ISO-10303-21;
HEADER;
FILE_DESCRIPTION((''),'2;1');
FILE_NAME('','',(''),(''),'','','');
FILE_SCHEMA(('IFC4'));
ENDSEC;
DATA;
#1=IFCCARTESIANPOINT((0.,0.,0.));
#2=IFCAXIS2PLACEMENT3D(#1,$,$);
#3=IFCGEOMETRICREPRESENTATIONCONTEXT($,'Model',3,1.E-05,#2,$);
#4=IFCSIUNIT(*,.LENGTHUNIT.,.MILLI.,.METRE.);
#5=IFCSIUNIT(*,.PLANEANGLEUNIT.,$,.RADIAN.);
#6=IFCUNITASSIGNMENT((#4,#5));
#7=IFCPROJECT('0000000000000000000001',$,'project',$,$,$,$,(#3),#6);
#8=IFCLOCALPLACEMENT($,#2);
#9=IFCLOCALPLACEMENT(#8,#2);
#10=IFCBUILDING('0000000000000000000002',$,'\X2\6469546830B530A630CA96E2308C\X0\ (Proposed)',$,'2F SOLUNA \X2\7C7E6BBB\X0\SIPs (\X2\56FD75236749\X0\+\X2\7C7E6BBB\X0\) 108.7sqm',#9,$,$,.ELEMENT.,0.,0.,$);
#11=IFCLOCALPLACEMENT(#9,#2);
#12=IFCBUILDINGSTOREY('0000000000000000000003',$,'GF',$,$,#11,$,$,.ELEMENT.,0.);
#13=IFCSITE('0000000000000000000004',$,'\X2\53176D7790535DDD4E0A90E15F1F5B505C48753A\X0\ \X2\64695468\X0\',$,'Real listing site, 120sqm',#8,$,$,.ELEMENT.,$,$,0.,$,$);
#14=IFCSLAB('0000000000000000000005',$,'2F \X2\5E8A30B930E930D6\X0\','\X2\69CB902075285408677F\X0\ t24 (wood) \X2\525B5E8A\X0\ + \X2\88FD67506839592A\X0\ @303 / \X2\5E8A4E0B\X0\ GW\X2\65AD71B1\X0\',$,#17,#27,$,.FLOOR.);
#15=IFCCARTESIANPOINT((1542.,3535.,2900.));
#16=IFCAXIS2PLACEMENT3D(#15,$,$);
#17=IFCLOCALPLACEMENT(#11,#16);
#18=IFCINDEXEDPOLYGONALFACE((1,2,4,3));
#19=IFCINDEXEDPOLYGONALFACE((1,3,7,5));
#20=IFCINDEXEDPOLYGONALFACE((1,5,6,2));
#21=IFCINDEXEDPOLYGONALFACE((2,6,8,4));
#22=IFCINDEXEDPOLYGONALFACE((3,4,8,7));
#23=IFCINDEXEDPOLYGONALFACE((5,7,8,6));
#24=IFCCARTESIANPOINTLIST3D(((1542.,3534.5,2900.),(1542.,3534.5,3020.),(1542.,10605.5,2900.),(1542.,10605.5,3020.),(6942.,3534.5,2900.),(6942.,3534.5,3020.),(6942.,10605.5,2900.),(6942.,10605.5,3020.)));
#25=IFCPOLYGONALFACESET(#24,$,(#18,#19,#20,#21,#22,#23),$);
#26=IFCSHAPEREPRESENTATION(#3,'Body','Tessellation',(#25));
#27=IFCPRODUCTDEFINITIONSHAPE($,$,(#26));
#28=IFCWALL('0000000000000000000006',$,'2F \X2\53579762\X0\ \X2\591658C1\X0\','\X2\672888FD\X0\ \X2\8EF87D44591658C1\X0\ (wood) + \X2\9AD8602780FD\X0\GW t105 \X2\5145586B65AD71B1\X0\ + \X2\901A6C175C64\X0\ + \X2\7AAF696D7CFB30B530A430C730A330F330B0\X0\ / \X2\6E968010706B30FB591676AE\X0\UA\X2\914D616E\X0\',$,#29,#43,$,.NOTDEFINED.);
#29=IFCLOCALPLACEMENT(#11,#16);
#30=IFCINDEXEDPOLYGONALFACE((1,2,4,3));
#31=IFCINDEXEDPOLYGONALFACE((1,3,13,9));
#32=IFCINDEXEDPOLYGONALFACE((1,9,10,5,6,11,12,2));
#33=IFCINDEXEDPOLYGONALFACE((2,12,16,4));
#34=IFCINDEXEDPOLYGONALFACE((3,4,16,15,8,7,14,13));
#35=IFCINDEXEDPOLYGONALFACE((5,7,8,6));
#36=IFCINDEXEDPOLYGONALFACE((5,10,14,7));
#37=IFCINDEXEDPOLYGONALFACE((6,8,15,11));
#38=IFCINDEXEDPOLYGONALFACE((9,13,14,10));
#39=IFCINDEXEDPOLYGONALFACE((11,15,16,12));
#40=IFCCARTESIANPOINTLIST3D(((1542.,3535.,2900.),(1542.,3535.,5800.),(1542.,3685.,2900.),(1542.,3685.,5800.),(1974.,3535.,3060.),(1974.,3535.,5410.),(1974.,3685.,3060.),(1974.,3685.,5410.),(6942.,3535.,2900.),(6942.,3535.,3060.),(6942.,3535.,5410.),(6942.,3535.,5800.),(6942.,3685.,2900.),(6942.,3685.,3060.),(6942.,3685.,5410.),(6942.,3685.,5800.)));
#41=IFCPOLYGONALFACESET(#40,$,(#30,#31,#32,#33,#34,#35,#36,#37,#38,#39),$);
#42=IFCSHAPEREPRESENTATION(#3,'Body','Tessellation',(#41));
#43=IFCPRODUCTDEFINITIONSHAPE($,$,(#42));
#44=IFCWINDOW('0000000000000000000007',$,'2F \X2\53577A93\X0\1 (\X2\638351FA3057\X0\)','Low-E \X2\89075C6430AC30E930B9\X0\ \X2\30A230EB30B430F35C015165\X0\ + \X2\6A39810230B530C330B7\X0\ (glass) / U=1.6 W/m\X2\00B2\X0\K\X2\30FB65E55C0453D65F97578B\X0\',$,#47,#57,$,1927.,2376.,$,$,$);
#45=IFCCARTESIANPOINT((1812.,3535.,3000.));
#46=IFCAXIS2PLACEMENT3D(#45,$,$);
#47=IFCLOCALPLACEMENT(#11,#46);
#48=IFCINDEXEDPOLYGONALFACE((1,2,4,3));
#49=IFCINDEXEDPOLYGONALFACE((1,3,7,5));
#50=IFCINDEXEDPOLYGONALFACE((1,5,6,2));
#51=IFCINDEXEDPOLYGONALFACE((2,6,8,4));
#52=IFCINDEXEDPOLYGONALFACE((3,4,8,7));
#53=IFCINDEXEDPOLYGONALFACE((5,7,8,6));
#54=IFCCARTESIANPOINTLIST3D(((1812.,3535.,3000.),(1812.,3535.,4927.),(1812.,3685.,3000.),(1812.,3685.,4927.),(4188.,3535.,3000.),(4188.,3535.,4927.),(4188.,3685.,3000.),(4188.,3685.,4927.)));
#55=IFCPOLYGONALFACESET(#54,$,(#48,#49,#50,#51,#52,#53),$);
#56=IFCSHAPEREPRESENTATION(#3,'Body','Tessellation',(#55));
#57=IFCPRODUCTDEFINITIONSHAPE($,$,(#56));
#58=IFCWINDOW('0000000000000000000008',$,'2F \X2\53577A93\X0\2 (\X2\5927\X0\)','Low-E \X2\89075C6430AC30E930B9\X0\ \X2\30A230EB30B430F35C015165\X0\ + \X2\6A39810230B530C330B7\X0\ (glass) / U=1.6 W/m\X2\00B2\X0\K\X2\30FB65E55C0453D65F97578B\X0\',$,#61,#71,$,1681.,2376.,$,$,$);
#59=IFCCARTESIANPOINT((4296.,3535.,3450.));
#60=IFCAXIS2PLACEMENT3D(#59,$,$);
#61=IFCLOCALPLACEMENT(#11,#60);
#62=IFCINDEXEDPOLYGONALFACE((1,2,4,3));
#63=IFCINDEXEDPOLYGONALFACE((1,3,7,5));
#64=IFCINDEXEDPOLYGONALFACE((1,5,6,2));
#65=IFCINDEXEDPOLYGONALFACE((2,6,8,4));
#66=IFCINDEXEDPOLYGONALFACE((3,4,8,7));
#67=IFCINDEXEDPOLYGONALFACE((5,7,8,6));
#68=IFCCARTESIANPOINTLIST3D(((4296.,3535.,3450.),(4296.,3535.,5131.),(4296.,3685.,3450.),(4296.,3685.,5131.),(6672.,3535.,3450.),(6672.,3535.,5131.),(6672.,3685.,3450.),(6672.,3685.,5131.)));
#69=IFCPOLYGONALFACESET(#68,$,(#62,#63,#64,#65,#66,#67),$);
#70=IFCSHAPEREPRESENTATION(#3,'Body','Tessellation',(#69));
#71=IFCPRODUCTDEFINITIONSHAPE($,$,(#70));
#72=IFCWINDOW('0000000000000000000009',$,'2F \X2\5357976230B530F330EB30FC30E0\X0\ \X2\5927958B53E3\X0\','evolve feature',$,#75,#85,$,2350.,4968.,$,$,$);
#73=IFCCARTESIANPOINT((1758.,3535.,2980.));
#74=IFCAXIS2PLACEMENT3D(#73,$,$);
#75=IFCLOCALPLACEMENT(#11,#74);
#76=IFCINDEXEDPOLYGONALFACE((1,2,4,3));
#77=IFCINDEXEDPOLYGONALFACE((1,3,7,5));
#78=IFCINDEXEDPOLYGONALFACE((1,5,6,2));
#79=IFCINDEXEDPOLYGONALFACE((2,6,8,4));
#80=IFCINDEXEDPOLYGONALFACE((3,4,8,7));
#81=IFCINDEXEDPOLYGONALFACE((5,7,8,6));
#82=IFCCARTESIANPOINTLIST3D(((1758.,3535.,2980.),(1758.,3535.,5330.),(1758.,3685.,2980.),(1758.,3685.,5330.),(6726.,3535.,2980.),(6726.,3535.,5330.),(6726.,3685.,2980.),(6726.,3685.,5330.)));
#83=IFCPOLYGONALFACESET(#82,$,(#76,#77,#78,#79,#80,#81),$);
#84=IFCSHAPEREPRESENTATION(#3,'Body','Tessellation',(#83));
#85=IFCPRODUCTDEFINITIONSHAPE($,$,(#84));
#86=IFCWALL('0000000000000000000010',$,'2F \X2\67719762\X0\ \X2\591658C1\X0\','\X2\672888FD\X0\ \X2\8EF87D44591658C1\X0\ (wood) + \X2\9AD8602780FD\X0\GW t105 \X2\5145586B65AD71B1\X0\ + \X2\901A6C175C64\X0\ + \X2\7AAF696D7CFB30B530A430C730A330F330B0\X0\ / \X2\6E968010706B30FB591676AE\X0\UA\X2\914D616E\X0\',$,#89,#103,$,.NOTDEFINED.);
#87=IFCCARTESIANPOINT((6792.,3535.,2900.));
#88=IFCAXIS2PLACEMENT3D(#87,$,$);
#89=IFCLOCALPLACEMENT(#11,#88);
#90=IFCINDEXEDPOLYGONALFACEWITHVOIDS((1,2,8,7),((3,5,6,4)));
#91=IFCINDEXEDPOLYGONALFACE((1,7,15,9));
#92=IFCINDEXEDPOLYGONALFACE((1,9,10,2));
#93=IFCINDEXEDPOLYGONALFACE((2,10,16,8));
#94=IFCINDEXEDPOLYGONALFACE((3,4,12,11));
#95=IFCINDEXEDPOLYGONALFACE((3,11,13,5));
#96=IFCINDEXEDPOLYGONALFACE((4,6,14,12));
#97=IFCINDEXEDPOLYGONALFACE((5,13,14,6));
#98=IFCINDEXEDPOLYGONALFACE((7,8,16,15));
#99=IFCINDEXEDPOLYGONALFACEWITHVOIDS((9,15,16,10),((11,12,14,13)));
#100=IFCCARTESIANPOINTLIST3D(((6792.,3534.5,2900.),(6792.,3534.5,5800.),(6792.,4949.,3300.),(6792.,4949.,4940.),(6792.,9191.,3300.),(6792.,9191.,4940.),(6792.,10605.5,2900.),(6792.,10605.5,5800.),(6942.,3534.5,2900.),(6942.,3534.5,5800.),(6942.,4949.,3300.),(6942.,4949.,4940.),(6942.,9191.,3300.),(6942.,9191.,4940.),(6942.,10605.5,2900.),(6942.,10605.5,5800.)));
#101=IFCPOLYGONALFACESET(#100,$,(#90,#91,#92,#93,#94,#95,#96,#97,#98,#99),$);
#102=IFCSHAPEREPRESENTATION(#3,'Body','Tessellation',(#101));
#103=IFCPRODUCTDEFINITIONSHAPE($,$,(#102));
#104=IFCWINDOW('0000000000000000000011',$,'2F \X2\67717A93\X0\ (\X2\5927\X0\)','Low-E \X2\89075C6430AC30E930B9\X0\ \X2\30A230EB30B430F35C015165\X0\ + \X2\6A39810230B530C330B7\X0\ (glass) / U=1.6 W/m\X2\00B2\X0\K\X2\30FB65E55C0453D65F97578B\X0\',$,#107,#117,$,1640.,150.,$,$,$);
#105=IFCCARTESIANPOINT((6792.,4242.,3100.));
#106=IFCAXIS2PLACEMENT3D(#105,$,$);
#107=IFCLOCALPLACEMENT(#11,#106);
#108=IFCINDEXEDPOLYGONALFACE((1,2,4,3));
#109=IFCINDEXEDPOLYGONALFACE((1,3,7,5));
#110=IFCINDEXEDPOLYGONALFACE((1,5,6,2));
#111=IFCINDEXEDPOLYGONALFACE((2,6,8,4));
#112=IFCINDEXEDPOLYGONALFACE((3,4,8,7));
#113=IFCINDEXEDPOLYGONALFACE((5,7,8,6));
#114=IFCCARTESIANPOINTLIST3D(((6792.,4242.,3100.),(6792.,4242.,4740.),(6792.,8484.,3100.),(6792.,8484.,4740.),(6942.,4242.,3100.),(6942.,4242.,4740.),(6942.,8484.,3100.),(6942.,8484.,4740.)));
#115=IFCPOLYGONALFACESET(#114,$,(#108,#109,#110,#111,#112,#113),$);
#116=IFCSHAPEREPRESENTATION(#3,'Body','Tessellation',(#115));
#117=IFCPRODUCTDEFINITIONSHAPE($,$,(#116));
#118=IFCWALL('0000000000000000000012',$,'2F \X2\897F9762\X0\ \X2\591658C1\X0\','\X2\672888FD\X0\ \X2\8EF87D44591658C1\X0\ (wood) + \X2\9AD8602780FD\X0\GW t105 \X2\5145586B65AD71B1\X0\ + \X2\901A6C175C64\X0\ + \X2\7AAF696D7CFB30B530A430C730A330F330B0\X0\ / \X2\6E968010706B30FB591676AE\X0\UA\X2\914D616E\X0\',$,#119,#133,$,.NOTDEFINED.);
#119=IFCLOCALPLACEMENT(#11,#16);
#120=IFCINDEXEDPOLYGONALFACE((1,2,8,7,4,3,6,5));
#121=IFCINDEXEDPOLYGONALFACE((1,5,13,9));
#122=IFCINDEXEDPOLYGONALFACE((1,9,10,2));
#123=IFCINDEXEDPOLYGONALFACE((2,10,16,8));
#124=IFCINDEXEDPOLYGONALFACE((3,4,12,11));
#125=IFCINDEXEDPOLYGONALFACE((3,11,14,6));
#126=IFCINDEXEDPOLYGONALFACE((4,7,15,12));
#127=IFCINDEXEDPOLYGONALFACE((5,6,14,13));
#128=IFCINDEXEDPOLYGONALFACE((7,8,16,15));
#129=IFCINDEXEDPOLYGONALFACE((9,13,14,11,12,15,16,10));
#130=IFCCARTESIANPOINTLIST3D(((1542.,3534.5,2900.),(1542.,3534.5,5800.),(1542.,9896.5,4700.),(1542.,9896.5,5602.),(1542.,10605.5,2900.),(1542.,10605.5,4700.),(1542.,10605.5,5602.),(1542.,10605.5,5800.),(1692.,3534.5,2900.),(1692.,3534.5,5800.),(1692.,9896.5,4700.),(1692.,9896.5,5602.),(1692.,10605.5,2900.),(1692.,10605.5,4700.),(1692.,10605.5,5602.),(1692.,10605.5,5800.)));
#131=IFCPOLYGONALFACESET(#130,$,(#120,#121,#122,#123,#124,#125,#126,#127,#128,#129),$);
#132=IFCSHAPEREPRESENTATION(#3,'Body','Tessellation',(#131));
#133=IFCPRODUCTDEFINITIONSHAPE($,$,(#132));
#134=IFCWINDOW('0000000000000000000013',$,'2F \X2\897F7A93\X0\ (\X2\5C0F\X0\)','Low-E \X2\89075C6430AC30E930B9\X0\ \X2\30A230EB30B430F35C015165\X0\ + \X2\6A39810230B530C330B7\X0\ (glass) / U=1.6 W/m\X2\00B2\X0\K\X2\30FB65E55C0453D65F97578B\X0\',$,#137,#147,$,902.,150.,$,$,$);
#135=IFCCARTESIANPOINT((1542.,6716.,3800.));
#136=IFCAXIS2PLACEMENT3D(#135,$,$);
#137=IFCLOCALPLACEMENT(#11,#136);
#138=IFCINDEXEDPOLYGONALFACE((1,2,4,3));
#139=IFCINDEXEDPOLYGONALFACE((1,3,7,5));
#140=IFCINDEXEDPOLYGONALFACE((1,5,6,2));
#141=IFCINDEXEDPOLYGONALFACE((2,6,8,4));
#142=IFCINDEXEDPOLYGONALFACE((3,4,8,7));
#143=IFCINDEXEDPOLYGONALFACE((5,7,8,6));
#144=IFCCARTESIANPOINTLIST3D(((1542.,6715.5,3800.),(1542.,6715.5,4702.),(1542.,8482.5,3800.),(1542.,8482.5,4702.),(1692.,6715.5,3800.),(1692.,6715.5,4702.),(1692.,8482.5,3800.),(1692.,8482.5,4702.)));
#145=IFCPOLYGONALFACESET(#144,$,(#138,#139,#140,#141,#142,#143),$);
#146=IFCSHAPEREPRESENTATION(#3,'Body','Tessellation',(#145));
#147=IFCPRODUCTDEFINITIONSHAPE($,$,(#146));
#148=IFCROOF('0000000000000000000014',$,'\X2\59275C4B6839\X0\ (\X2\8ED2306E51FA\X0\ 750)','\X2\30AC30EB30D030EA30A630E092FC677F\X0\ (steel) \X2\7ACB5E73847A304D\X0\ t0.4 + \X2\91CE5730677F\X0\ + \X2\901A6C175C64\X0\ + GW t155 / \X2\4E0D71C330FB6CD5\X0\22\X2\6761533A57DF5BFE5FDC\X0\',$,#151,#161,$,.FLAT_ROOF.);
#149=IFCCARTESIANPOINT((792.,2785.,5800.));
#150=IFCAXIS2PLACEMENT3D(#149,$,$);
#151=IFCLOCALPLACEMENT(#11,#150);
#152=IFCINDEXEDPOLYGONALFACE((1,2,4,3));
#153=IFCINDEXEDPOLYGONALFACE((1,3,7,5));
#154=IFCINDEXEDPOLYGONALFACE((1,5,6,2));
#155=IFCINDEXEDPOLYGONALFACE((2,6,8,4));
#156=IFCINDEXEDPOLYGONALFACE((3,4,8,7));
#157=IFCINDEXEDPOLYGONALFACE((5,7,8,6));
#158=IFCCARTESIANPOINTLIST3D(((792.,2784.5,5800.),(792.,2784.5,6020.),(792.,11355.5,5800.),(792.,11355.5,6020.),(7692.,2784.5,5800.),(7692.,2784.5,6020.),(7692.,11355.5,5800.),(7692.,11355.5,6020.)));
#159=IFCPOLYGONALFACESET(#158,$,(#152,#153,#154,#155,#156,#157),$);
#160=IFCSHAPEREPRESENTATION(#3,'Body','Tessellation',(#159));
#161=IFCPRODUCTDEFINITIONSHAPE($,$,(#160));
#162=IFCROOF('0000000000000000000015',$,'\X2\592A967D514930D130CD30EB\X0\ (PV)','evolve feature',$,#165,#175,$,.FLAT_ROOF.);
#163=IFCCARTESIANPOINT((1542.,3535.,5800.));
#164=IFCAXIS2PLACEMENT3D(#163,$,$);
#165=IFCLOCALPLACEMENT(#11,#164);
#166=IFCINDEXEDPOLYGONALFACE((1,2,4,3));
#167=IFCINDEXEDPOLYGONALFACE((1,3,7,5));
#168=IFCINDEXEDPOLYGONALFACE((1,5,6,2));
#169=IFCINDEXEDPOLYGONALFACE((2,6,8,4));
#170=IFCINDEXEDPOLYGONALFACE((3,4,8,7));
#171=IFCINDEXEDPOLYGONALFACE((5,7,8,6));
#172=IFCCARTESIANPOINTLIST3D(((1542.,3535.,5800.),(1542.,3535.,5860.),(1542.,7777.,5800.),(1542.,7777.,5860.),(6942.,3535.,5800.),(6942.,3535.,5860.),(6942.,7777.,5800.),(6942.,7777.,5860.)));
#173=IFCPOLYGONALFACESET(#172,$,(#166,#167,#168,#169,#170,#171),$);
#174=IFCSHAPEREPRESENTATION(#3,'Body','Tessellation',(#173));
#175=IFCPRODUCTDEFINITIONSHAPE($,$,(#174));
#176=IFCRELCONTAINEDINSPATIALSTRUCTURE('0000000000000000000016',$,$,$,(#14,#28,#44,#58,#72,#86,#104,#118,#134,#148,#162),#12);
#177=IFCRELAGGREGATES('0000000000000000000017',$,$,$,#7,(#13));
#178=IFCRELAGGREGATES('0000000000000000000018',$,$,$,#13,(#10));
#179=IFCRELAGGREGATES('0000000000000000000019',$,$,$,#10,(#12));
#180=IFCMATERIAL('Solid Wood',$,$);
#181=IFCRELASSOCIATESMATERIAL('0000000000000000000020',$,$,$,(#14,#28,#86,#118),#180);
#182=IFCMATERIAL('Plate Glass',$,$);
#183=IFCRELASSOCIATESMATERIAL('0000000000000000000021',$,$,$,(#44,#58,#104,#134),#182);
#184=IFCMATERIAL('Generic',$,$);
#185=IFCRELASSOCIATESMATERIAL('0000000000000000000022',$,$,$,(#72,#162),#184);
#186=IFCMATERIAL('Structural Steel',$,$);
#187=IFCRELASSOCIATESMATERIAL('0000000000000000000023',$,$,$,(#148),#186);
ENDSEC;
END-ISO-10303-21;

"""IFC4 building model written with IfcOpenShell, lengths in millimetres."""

from ifc_helpers import new_model, si_unit, frame, frame_2d, origin, place, context, project, spatial, rectangle, extrude, material, element, fill, save


model = new_model("IFC4")

# Units and contexts
model_context = context("Model", 3, precision=1e-05, world=origin())
ifc_project = project(units=[si_unit("LENGTHUNIT", "METRE", prefix="MILLI"), si_unit("PLANEANGLEUNIT", "RADIAN")], contexts=[model_context])

# Site, building, storey
site_placement = place(None, origin())
site = spatial("IfcSite", under=ifc_project, at=site_placement, Name="北海道川上郡弟子屈町 摩周", ObjectType="Real listing site, 120sqm", CompositionType="ELEMENT", RefElevation=0.0)
building_placement = place(site_placement, origin())
building = spatial("IfcBuilding", under=site, at=building_placement, Name="摩周サウナ離れ (Proposed)", ObjectType="2F SOLUNA 籾殻SIPs (国産杉+籾殻) 108.7sqm", CompositionType="ELEMENT", ElevationOfRefHeight=0.0, ElevationOfTerrain=0.0)
storey_placement = place(building_placement, origin())
storey = spatial("IfcBuildingStorey", under=building, at=storey_placement, Name="GF", CompositionType="ELEMENT", Elevation=0.0)

# Slab
ifc_material_1 = material(Name="Solid Wood")
slab_placement = place(storey_placement, frame((1542.0, 3535.0, 2900.0)))
element("IfcSlab", 1, at=slab_placement, inside=storey, material=ifc_material_1, Name="2F 床スラブ", Description="構造用合板 t24 (wood) 剛床 + 製材根太 @303 / 床下 GW断熱", PredefinedType="FLOOR", context=model_context, shape_type="SweptSolid", body=[
    extrude(rectangle(XDim=5400.0, YDim=7071.0, at=frame_2d((2700.0, 3535.0))), frame((1542.0, 3535.0, 2900.0)), (0.0, 0.0, 1.0), 120.0),
])

# Wall, openings, windows
wall_1_placement = place(storey_placement, frame((1542.0, 3535.0, 2900.0)))
wall_1 = element("IfcWall", 2, at=wall_1_placement, inside=storey, material=ifc_material_1, Name="2F 南面 外壁", Description="木製 軸組外壁 (wood) + 高性能GW t105 充填断熱 + 通気層 + 窯業系サイディング / 準耐火・外皮UA配慮", PredefinedType="NOTDEFINED", context=model_context, shape_type="SweptSolid", body=[
    extrude(rectangle(XDim=5400.0, YDim=150.0, at=frame_2d((2700.0, 75.0))), frame((1542.0, 3535.0, 2900.0)), (0.0, 0.0, 1.0), 2900.0),
])
opening_1_placement = place(storey_placement, frame((1812.0, 3535.0, 3000.0)))
opening_1 = element("IfcOpeningElement", 3, at=opening_1_placement, cuts=wall_1, PredefinedType="NOTDEFINED", context=model_context, shape_type="SweptSolid", body=[
    extrude(rectangle(XDim=2376.0, YDim=150.0, at=frame_2d((1188.0, 75.0))), frame((1812.0, 3535.0, 3000.0)), (0.0, 0.0, 1.0), 1927.0),
])
opening_2_placement = place(storey_placement, frame((4296.0, 3535.0, 3450.0)))
opening_2 = element("IfcOpeningElement", 4, at=opening_2_placement, cuts=wall_1, PredefinedType="NOTDEFINED", context=model_context, shape_type="SweptSolid", body=[
    extrude(rectangle(XDim=2376.0, YDim=150.0, at=frame_2d((1188.0, 75.0))), frame((4296.0, 3535.0, 3450.0)), (0.0, 0.0, 1.0), 1681.0),
])
opening_3_placement = place(storey_placement, frame((1758.0, 3535.0, 2980.0)))
opening_3 = element("IfcOpeningElement", 5, at=opening_3_placement, cuts=wall_1, PredefinedType="NOTDEFINED", context=model_context, shape_type="SweptSolid", body=[
    extrude(rectangle(XDim=4968.0, YDim=150.0, at=frame_2d((2484.0, 75.0))), frame((1758.0, 3535.0, 2980.0)), (0.0, 0.0, 1.0), 2350.0),
])
ifc_material_2 = material(Name="Plate Glass")
window_1_placement = place(storey_placement, frame((1812.0, 3535.0, 3000.0)))
window_1 = element("IfcWindow", 6, at=window_1_placement, inside=storey, material=ifc_material_2, Name="2F 南窓1 (掃出し)", Description="Low-E 複層ガラス アルゴン封入 + 樹脂サッシ (glass) / U=1.6 W/m²K・日射取得型", OverallHeight=1927.0, OverallWidth=2376.0, context=model_context, shape_type="SweptSolid", body=[
    extrude(rectangle(XDim=2376.0, YDim=150.0, at=frame_2d((1188.0, 75.0))), frame((1812.0, 3535.0, 3000.0)), (0.0, 0.0, 1.0), 1927.0),
])
fill(opening_1, window_1)
window_2_placement = place(storey_placement, frame((4296.0, 3535.0, 3450.0)))
window_2 = element("IfcWindow", 7, at=window_2_placement, inside=storey, material=ifc_material_2, Name="2F 南窓2 (大)", Description="Low-E 複層ガラス アルゴン封入 + 樹脂サッシ (glass) / U=1.6 W/m²K・日射取得型", OverallHeight=1681.0, OverallWidth=2376.0, context=model_context, shape_type="SweptSolid", body=[
    extrude(rectangle(XDim=2376.0, YDim=150.0, at=frame_2d((1188.0, 75.0))), frame((4296.0, 3535.0, 3450.0)), (0.0, 0.0, 1.0), 1681.0),
])
fill(opening_2, window_2)
ifc_material_3 = material(Name="Generic")
window_3_placement = place(storey_placement, frame((1758.0, 3535.0, 2980.0)))
window_3 = element("IfcWindow", 8, at=window_3_placement, inside=storey, material=ifc_material_3, Name="2F 南面サンルーム 大開口", Description="evolve feature", OverallHeight=2350.0, OverallWidth=4968.0, context=model_context, shape_type="SweptSolid", body=[
    extrude(rectangle(XDim=4968.0, YDim=150.0, at=frame_2d((2484.0, 75.0))), frame((1758.0, 3535.0, 2980.0)), (0.0, 0.0, 1.0), 2350.0),
])
fill(opening_3, window_3)

# Walls, openings, windows
wall_2_placement = place(storey_placement, frame((6792.0, 3535.0, 2900.0)))
wall_2 = element("IfcWall", 9, at=wall_2_placement, inside=storey, material=ifc_material_1, Name="2F 東面 外壁", Description="木製 軸組外壁 (wood) + 高性能GW t105 充填断熱 + 通気層 + 窯業系サイディング / 準耐火・外皮UA配慮", PredefinedType="NOTDEFINED", context=model_context, shape_type="SweptSolid", body=[
    extrude(rectangle(XDim=150.0, YDim=7071.0, at=frame_2d((75.0, 3535.0))), frame((6792.0, 3535.0, 2900.0)), (0.0, 0.0, 1.0), 2900.0),
])
opening_4_placement = place(storey_placement, frame((6792.0, 4242.0, 3100.0)))
opening_4 = element("IfcOpeningElement", 10, at=opening_4_placement, cuts=wall_2, PredefinedType="NOTDEFINED", context=model_context, shape_type="SweptSolid", body=[
    extrude(rectangle(XDim=150.0, YDim=4242.0, at=frame_2d((75.0, 2121.0))), frame((6792.0, 4242.0, 3100.0)), (0.0, 0.0, 1.0), 1640.0),
])
window_4_placement = place(storey_placement, frame((6792.0, 4242.0, 3100.0)))
window_4 = element("IfcWindow", 11, at=window_4_placement, inside=storey, material=ifc_material_2, Name="2F 東窓 (大)", Description="Low-E 複層ガラス アルゴン封入 + 樹脂サッシ (glass) / U=1.6 W/m²K・日射取得型", OverallHeight=1640.0, OverallWidth=150.0, context=model_context, shape_type="SweptSolid", body=[
    extrude(rectangle(XDim=150.0, YDim=4242.0, at=frame_2d((75.0, 2121.0))), frame((6792.0, 4242.0, 3100.0)), (0.0, 0.0, 1.0), 1640.0),
])
fill(opening_4, window_4)
wall_3_placement = place(storey_placement, frame((1542.0, 3535.0, 2900.0)))
wall_3 = element("IfcWall", 12, at=wall_3_placement, inside=storey, material=ifc_material_1, Name="2F 西面 外壁", Description="木製 軸組外壁 (wood) + 高性能GW t105 充填断熱 + 通気層 + 窯業系サイディング / 準耐火・外皮UA配慮", PredefinedType="NOTDEFINED", context=model_context, shape_type="SweptSolid", body=[
    extrude(rectangle(XDim=150.0, YDim=7071.0, at=frame_2d((75.0, 3535.0))), frame((1542.0, 3535.0, 2900.0)), (0.0, 0.0, 1.0), 2900.0),
])
opening_5_placement = place(storey_placement, frame((1542.0, 6716.0, 3800.0)))
opening_5 = element("IfcOpeningElement", 13, at=opening_5_placement, cuts=wall_3, PredefinedType="NOTDEFINED", context=model_context, shape_type="SweptSolid", body=[
    extrude(rectangle(XDim=150.0, YDim=1767.0, at=frame_2d((75.0, 883.0))), frame((1542.0, 6716.0, 3800.0)), (0.0, 0.0, 1.0), 902.0),
])
window_5_placement = place(storey_placement, frame((1542.0, 6716.0, 3800.0)))
window_5 = element("IfcWindow", 14, at=window_5_placement, inside=storey, material=ifc_material_2, Name="2F 西窓 (小)", Description="Low-E 複層ガラス アルゴン封入 + 樹脂サッシ (glass) / U=1.6 W/m²K・日射取得型", OverallHeight=902.0, OverallWidth=150.0, context=model_context, shape_type="SweptSolid", body=[
    extrude(rectangle(XDim=150.0, YDim=1767.0, at=frame_2d((75.0, 883.0))), frame((1542.0, 6716.0, 3800.0)), (0.0, 0.0, 1.0), 902.0),
])
fill(opening_5, window_5)

# Roofs
ifc_material_4 = material(Name="Structural Steel")
roof_1_placement = place(storey_placement, frame((792.0, 2785.0, 5800.0)))
element("IfcRoof", 15, at=roof_1_placement, inside=storey, material=ifc_material_4, Name="大屋根 (軒の出 750)", Description="ガルバリウム鋼板 (steel) 立平葺き t0.4 + 野地板 + 通気層 + GW t155 / 不燃・法22条区域対応", PredefinedType="FLAT_ROOF", context=model_context, shape_type="SweptSolid", body=[
    extrude(rectangle(XDim=6900.0, YDim=8571.0, at=frame_2d((3450.0, 4285.0))), frame((792.0, 2785.0, 5800.0)), (0.0, 0.0, 1.0), 220.0),
])
roof_2_placement = place(storey_placement, frame((1542.0, 3535.0, 5800.0)))
element("IfcRoof", 16, at=roof_2_placement, inside=storey, material=ifc_material_3, Name="太陽光パネル (PV)", Description="evolve feature", PredefinedType="FLAT_ROOF", context=model_context, shape_type="SweptSolid", body=[
    extrude(rectangle(XDim=5400.0, YDim=4242.0, at=frame_2d((2700.0, 2121.0))), frame((1542.0, 3535.0, 5800.0)), (0.0, 0.0, 1.0), 60.0),
])

save(model, "model.ifc")
